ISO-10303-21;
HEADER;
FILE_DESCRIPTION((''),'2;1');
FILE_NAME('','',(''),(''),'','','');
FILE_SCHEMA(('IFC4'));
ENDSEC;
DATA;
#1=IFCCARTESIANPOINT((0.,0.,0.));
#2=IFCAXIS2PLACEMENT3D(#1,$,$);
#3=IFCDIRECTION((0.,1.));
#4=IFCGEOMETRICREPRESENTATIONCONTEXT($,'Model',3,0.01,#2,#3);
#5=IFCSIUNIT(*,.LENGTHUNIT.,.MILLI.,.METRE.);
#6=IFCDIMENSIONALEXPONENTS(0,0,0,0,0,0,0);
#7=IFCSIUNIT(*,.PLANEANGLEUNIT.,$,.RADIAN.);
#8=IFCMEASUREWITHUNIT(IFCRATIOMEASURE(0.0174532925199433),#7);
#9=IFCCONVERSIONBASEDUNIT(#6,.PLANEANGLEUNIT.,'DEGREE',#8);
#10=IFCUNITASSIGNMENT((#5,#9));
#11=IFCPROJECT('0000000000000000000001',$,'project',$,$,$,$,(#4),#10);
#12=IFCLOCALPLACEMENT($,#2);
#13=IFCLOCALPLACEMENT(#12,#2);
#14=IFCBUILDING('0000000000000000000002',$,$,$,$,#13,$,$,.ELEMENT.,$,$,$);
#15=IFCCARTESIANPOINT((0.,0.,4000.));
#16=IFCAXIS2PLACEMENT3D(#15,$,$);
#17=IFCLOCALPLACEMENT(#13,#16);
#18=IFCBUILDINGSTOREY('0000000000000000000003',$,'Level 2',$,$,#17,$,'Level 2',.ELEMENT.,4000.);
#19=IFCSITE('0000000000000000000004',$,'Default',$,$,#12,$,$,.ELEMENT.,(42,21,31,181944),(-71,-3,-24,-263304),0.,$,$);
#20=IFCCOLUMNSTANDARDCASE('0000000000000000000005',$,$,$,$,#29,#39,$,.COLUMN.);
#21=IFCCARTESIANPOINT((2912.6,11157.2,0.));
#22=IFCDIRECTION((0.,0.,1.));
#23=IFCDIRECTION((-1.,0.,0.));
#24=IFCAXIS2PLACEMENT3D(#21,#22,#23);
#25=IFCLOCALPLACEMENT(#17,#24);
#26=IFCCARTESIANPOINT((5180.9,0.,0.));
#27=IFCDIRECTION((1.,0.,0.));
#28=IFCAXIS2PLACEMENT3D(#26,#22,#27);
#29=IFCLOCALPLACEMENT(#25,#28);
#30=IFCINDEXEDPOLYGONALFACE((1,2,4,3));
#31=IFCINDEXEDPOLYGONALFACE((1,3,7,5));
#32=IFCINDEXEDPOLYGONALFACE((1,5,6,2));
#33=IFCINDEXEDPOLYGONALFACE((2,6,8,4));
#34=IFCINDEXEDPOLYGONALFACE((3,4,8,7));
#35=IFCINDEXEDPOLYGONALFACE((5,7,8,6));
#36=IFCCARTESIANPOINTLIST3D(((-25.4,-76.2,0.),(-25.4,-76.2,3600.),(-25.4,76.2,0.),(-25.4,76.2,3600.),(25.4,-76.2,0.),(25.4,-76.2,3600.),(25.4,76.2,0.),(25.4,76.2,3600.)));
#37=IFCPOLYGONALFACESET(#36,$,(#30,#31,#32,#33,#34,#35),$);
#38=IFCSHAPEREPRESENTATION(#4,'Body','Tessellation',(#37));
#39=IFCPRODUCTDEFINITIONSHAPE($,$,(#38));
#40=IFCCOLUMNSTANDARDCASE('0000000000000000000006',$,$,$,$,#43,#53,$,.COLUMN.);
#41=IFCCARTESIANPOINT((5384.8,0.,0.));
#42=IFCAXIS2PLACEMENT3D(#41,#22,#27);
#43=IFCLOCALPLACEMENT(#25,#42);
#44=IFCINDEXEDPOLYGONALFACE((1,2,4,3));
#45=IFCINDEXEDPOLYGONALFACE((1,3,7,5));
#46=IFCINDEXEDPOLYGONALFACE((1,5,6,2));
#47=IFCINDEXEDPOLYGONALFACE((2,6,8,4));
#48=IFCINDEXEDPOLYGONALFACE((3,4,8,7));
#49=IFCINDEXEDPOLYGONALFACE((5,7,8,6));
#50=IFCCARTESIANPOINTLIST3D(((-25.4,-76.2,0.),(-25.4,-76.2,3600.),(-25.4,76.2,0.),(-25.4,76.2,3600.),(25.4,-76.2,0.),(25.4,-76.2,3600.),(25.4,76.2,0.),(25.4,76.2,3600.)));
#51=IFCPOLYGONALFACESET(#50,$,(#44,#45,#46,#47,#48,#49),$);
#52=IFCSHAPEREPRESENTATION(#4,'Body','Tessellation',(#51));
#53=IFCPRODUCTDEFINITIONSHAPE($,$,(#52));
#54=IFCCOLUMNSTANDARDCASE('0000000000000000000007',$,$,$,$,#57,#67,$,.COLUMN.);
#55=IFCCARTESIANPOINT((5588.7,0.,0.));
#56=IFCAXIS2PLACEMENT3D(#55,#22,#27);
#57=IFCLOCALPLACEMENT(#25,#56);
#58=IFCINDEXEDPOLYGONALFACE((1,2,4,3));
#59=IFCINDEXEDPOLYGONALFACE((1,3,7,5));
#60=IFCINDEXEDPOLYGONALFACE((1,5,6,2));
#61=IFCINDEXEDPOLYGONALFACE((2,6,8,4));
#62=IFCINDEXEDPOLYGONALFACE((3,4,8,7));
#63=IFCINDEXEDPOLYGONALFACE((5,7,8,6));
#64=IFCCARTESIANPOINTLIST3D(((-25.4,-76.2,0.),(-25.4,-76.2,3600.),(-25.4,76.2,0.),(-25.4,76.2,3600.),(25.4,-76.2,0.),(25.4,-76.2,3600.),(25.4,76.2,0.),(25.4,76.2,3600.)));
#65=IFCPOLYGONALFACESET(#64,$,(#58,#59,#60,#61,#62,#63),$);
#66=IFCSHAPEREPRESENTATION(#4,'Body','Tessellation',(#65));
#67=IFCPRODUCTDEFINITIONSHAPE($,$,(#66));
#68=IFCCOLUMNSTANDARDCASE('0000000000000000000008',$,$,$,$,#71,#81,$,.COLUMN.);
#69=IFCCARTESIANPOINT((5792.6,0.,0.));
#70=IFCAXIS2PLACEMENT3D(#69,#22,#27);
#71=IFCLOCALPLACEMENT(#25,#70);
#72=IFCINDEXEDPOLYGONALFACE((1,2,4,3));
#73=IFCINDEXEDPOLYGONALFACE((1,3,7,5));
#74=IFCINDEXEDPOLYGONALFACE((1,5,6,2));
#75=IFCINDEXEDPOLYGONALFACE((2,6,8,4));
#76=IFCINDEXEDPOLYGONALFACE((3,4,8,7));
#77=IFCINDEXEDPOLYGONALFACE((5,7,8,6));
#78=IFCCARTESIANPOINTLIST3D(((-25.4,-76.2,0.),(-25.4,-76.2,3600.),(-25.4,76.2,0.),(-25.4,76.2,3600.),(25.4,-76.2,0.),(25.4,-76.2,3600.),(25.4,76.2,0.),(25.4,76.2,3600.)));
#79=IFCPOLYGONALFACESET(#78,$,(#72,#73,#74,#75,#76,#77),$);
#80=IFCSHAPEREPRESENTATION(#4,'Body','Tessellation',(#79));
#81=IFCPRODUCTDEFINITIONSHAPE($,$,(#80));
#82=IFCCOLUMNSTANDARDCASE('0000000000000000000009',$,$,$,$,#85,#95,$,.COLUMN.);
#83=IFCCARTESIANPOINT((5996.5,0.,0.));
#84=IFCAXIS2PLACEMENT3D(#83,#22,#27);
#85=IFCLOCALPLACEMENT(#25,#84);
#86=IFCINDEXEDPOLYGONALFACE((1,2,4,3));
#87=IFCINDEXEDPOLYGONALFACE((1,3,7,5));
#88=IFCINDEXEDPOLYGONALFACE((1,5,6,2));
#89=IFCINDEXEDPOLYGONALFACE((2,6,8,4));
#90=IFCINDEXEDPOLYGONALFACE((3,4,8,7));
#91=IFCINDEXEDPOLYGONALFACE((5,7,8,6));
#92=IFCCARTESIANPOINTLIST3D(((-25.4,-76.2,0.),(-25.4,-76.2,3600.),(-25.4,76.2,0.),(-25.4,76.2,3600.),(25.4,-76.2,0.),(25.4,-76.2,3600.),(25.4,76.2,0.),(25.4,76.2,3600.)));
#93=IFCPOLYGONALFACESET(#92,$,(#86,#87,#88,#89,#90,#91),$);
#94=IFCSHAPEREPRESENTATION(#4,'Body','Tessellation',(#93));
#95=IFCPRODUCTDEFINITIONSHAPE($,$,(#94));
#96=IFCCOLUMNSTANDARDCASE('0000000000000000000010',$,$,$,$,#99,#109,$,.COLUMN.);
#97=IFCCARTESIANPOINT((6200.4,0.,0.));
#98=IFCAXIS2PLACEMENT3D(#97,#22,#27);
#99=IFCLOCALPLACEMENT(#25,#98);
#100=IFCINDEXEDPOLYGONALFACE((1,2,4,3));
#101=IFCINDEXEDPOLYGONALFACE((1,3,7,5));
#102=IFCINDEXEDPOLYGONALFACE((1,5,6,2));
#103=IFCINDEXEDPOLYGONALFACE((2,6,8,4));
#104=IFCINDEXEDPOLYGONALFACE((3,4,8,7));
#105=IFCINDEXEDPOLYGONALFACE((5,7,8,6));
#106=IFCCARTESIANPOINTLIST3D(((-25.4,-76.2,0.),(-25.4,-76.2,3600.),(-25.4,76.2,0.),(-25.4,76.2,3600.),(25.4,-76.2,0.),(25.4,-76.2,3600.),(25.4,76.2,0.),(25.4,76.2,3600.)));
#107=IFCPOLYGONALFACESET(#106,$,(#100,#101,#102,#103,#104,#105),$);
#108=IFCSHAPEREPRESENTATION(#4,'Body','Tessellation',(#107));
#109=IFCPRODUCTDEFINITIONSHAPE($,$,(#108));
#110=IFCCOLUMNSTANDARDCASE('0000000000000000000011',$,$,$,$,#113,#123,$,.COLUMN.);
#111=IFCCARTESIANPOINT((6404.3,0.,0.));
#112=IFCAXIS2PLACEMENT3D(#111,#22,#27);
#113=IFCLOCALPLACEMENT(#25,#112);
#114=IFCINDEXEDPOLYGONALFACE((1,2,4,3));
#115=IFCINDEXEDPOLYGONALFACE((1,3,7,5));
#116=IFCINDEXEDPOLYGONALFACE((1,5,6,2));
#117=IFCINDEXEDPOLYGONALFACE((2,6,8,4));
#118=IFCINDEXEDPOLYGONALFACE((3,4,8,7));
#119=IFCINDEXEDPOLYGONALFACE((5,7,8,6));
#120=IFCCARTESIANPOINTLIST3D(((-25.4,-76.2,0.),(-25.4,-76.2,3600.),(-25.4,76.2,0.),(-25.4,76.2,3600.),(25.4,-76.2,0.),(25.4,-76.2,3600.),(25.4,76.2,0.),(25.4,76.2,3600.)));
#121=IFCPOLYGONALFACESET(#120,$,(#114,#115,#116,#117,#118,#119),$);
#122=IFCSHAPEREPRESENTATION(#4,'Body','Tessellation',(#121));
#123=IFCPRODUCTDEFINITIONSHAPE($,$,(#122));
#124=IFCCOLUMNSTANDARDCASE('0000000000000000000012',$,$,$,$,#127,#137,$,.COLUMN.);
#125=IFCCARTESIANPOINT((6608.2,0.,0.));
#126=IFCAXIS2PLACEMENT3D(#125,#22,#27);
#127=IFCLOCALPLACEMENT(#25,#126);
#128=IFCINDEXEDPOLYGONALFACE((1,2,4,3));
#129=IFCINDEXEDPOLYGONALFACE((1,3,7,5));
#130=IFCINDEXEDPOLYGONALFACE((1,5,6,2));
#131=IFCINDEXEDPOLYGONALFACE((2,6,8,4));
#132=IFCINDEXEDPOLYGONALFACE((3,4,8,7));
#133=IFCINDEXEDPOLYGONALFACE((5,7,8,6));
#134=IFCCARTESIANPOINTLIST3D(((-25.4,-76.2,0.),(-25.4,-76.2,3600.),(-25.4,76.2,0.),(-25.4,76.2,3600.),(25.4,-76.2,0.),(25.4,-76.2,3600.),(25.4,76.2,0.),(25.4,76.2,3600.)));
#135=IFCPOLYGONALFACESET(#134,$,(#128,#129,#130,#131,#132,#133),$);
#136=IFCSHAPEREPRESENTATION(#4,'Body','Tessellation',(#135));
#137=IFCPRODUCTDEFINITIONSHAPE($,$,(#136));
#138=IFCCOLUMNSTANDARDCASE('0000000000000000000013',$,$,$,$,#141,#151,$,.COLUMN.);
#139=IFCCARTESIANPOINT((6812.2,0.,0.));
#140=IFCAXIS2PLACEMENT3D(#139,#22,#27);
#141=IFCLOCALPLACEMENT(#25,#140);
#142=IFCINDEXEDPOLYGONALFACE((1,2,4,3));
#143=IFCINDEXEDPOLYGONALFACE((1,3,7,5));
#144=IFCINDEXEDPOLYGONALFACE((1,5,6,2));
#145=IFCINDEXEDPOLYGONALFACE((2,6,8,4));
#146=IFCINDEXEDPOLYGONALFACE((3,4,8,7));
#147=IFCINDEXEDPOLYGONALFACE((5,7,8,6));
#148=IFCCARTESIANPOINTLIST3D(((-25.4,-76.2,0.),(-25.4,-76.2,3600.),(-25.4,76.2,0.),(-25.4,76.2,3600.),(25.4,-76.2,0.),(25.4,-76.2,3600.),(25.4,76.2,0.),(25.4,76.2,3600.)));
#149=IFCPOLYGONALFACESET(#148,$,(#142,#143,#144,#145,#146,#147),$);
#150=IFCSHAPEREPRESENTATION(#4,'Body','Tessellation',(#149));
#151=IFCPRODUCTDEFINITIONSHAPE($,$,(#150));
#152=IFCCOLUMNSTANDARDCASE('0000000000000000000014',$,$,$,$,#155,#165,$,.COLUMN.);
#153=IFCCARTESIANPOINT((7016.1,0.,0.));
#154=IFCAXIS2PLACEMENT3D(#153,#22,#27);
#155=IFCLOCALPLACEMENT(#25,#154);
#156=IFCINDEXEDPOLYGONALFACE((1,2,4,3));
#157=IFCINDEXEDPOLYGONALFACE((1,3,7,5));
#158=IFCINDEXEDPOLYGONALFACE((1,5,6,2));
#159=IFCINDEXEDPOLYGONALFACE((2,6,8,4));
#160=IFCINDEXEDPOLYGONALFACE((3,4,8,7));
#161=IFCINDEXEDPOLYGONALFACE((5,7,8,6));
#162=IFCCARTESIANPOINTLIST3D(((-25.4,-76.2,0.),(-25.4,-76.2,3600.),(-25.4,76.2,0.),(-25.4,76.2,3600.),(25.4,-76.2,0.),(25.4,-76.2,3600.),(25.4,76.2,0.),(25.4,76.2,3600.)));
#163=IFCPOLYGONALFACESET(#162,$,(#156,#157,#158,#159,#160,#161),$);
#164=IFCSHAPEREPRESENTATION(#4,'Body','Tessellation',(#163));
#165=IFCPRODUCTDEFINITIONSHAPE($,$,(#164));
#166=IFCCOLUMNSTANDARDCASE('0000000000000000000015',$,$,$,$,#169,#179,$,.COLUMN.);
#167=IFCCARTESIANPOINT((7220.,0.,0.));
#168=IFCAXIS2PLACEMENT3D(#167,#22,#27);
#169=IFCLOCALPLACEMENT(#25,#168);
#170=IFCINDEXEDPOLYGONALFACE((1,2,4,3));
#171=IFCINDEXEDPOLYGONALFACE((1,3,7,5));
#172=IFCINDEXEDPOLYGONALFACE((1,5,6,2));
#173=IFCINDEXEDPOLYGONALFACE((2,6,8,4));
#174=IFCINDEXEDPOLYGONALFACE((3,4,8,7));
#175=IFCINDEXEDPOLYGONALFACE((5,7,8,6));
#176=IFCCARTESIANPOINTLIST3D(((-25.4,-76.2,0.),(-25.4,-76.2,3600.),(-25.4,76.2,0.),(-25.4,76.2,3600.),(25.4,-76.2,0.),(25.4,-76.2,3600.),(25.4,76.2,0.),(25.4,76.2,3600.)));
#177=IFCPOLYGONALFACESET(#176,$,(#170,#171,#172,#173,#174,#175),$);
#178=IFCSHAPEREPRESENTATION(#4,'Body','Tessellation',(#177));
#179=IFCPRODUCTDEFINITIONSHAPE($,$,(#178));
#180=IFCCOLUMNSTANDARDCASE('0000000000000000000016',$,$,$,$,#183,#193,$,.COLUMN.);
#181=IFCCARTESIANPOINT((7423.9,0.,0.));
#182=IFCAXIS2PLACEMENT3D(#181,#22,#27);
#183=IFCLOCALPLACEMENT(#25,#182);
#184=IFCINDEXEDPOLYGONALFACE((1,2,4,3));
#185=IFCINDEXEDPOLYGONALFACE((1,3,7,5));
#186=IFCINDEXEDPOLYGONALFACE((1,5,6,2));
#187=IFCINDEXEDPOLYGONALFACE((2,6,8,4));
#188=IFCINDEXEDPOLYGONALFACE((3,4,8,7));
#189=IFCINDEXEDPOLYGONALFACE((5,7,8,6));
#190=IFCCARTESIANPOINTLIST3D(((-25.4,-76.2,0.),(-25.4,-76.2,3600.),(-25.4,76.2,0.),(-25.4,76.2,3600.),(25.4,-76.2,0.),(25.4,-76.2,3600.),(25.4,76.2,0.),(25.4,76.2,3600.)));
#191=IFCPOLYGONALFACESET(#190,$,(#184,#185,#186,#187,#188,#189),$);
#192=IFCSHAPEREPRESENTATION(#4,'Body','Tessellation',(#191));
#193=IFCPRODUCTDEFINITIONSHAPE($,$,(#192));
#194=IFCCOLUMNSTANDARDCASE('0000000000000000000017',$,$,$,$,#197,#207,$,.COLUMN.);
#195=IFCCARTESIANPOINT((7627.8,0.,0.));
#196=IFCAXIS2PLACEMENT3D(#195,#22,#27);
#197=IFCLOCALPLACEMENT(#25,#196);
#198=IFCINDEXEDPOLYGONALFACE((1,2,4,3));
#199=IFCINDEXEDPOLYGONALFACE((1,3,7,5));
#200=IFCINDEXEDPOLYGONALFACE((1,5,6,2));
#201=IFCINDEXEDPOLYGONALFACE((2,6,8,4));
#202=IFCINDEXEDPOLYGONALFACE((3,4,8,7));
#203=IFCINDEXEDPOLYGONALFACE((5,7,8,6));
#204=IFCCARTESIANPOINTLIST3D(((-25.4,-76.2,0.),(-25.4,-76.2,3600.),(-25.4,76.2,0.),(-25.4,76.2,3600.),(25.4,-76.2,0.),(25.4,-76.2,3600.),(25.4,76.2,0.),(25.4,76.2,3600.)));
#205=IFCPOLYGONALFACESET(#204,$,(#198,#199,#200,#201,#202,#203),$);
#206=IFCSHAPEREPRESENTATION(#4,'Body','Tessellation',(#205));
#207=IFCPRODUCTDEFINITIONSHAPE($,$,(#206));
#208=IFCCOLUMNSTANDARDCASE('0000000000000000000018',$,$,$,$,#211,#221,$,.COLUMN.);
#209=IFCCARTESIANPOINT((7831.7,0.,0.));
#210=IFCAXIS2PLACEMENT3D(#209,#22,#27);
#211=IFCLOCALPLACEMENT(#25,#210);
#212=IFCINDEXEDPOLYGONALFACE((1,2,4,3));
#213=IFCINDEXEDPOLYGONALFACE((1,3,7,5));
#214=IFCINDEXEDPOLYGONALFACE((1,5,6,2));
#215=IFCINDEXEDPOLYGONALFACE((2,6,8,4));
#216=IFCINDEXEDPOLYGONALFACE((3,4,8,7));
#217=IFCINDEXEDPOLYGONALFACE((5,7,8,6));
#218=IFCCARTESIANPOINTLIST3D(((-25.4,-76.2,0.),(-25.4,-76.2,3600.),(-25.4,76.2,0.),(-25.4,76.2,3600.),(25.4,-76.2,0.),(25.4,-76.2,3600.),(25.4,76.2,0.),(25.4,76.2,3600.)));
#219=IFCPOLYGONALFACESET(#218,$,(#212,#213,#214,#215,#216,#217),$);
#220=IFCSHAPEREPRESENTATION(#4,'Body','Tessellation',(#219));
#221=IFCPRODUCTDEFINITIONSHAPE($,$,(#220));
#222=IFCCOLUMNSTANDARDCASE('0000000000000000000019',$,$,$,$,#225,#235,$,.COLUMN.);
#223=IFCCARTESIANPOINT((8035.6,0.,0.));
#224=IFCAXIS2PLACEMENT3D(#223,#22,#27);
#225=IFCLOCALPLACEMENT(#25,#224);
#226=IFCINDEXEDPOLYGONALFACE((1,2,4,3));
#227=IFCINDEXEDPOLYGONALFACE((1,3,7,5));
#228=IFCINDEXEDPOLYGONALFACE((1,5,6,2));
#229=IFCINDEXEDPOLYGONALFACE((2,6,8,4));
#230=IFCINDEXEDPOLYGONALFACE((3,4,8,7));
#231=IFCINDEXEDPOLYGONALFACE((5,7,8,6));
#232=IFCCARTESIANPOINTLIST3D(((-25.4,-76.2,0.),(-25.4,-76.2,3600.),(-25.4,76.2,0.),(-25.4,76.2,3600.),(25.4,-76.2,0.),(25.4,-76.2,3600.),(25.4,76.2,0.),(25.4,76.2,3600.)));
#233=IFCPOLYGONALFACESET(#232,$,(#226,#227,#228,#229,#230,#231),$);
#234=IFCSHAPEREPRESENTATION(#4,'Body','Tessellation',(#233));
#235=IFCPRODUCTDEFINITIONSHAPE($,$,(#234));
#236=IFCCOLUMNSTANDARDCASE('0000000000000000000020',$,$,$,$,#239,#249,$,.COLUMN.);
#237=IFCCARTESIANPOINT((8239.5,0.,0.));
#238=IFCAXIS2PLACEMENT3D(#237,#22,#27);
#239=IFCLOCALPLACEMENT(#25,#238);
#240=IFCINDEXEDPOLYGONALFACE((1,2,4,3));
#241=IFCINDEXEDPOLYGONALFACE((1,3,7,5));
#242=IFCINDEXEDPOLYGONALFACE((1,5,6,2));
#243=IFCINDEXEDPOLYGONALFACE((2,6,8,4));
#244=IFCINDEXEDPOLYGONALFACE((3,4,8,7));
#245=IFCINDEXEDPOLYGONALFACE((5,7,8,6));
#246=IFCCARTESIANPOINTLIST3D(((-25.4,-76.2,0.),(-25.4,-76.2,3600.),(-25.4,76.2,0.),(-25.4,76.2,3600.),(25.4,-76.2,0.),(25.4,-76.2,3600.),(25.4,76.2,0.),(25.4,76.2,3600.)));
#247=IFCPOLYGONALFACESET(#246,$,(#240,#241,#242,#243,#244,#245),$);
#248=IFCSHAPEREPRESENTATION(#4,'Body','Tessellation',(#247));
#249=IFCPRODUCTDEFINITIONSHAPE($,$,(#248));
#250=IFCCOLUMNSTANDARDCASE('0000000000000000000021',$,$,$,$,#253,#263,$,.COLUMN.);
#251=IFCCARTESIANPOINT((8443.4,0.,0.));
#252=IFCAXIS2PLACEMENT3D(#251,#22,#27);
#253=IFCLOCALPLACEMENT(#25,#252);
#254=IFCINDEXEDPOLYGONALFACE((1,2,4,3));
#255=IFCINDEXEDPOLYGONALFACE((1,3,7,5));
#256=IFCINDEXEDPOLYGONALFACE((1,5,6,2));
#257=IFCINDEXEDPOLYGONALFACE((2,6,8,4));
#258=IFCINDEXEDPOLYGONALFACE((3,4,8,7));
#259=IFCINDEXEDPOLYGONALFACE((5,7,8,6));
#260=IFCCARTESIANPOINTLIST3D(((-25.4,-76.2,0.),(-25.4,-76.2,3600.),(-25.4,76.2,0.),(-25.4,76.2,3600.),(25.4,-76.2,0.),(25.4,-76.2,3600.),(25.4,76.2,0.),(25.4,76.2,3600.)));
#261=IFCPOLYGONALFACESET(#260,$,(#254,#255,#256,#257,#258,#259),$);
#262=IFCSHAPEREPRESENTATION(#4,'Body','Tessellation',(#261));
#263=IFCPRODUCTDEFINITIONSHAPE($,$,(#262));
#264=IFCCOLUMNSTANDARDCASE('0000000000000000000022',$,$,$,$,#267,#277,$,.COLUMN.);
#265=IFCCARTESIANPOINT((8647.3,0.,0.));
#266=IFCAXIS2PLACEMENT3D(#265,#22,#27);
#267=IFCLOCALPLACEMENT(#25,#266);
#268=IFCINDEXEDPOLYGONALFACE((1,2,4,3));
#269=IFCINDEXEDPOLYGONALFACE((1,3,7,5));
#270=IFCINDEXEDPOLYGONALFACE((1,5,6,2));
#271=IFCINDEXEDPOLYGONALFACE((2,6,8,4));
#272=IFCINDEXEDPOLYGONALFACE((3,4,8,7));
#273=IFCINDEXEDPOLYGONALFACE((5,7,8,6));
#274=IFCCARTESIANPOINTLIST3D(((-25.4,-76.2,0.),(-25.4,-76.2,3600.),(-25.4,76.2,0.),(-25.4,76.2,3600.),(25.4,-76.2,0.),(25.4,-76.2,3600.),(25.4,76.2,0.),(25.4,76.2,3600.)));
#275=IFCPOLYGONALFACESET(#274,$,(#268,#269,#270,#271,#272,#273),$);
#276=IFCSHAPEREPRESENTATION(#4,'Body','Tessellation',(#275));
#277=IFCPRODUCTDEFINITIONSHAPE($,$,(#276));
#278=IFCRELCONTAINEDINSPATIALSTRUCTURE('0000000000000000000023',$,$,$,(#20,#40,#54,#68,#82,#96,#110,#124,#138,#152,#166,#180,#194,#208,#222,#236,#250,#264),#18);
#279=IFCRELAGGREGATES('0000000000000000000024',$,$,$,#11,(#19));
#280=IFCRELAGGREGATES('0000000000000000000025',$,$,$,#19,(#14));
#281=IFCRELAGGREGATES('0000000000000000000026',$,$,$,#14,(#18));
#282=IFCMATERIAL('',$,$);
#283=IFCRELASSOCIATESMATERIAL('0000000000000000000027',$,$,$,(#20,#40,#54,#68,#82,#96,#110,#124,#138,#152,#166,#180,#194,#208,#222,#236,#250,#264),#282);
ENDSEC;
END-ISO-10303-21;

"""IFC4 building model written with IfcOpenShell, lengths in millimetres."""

from ifc_helpers import new_model, entity, si_unit, converted_unit, direction, frame, origin, place, context, project, spatial, rectangle, extrude, material, element, save


model = new_model("IFC4")

# Units and contexts
model_context = context("Model", 3, precision=0.01, world=origin(), true_north=direction((0.0, 1.0)))
ifc_project = project(units=[si_unit("LENGTHUNIT", "METRE", prefix="MILLI"), converted_unit("PLANEANGLEUNIT", "DEGREE", entity("IfcRatioMeasure", 0.0174532925199433), si_unit("PLANEANGLEUNIT", "RADIAN"), dimensions=[0, 0, 0, 0, 0, 0, 0])], contexts=[model_context])

# Site, building, storey
site_placement = place(None, origin())
site = spatial("IfcSite", under=ifc_project, at=site_placement, Name="Default", CompositionType="ELEMENT", RefLatitude=(42, 21, 31, 181944), RefLongitude=(-71, -3, -24, -263304), RefElevation=0.0)
building_placement = place(site_placement, origin())
building = spatial("IfcBuilding", under=site, at=building_placement, CompositionType="ELEMENT")
storey_placement = place(building_placement, frame((0.0, 0.0, 4000.0)))
storey = spatial("IfcBuildingStorey", under=building, at=storey_placement, Name="Level 2", LongName="Level 2", CompositionType="ELEMENT", Elevation=4000.0)

# Columns
ifc_material_1 = material(Name="")
placement_1 = place(storey_placement, frame((2912.6, 11157.2, 0.0), z_axis=(0.0, 0.0, 1.0), x_axis=(-1.0, 0.0, 0.0)))
for number, where, z_axis, x_axis in (
    (1, (5180.9, 0.0, 0.0), (0.0, 0.0, 1.0), (1.0, 0.0, 0.0)),
    (2, (5384.8, 0.0, 0.0), (0.0, 0.0, 1.0), (1.0, 0.0, 0.0)),
    (3, (5588.7, 0.0, 0.0), (0.0, 0.0, 1.0), (1.0, 0.0, 0.0)),
    (4, (5792.6, 0.0, 0.0), (0.0, 0.0, 1.0), (1.0, 0.0, 0.0)),
    (5, (5996.5, 0.0, 0.0), (0.0, 0.0, 1.0), (1.0, 0.0, 0.0)),
    (6, (6200.4, 0.0, 0.0), (0.0, 0.0, 1.0), (1.0, 0.0, 0.0)),
    (7, (6404.3, 0.0, 0.0), (0.0, 0.0, 1.0), (1.0, 0.0, 0.0)),
    (8, (6608.2, 0.0, 0.0), (0.0, 0.0, 1.0), (1.0, 0.0, 0.0)),
    (9, (6812.2, 0.0, 0.0), (0.0, 0.0, 1.0), (1.0, 0.0, 0.0)),
    (10, (7016.1, 0.0, 0.0), (0.0, 0.0, 1.0), (1.0, 0.0, 0.0)),
    (11, (7220.0, 0.0, 0.0), (0.0, 0.0, 1.0), (1.0, 0.0, 0.0)),
    (12, (7423.9, 0.0, 0.0), (0.0, 0.0, 1.0), (1.0, 0.0, 0.0)),
    (13, (7627.8, 0.0, 0.0), (0.0, 0.0, 1.0), (1.0, 0.0, 0.0)),
    (14, (7831.7, 0.0, 0.0), (0.0, 0.0, 1.0), (1.0, 0.0, 0.0)),
    (15, (8035.6, 0.0, 0.0), (0.0, 0.0, 1.0), (1.0, 0.0, 0.0)),
    (16, (8239.5, 0.0, 0.0), (0.0, 0.0, 1.0), (1.0, 0.0, 0.0)),
    (17, (8443.4, 0.0, 0.0), (0.0, 0.0, 1.0), (1.0, 0.0, 0.0)),
    (18, (8647.3, 0.0, 0.0), (0.0, 0.0, 1.0), (1.0, 0.0, 0.0)),
):
    element("IfcColumnStandardCase", number, at=place(placement_1, frame(where, z_axis=z_axis, x_axis=x_axis)), inside=storey, material=ifc_material_1, PredefinedType="COLUMN", context=model_context, shape_type="SweptSolid", body=[
        extrude(rectangle(XDim=50.8, YDim=152.4), origin(), (0.0, 0.0, 1.0), 3600.0),
    ])

save(model, "model.ifc")
